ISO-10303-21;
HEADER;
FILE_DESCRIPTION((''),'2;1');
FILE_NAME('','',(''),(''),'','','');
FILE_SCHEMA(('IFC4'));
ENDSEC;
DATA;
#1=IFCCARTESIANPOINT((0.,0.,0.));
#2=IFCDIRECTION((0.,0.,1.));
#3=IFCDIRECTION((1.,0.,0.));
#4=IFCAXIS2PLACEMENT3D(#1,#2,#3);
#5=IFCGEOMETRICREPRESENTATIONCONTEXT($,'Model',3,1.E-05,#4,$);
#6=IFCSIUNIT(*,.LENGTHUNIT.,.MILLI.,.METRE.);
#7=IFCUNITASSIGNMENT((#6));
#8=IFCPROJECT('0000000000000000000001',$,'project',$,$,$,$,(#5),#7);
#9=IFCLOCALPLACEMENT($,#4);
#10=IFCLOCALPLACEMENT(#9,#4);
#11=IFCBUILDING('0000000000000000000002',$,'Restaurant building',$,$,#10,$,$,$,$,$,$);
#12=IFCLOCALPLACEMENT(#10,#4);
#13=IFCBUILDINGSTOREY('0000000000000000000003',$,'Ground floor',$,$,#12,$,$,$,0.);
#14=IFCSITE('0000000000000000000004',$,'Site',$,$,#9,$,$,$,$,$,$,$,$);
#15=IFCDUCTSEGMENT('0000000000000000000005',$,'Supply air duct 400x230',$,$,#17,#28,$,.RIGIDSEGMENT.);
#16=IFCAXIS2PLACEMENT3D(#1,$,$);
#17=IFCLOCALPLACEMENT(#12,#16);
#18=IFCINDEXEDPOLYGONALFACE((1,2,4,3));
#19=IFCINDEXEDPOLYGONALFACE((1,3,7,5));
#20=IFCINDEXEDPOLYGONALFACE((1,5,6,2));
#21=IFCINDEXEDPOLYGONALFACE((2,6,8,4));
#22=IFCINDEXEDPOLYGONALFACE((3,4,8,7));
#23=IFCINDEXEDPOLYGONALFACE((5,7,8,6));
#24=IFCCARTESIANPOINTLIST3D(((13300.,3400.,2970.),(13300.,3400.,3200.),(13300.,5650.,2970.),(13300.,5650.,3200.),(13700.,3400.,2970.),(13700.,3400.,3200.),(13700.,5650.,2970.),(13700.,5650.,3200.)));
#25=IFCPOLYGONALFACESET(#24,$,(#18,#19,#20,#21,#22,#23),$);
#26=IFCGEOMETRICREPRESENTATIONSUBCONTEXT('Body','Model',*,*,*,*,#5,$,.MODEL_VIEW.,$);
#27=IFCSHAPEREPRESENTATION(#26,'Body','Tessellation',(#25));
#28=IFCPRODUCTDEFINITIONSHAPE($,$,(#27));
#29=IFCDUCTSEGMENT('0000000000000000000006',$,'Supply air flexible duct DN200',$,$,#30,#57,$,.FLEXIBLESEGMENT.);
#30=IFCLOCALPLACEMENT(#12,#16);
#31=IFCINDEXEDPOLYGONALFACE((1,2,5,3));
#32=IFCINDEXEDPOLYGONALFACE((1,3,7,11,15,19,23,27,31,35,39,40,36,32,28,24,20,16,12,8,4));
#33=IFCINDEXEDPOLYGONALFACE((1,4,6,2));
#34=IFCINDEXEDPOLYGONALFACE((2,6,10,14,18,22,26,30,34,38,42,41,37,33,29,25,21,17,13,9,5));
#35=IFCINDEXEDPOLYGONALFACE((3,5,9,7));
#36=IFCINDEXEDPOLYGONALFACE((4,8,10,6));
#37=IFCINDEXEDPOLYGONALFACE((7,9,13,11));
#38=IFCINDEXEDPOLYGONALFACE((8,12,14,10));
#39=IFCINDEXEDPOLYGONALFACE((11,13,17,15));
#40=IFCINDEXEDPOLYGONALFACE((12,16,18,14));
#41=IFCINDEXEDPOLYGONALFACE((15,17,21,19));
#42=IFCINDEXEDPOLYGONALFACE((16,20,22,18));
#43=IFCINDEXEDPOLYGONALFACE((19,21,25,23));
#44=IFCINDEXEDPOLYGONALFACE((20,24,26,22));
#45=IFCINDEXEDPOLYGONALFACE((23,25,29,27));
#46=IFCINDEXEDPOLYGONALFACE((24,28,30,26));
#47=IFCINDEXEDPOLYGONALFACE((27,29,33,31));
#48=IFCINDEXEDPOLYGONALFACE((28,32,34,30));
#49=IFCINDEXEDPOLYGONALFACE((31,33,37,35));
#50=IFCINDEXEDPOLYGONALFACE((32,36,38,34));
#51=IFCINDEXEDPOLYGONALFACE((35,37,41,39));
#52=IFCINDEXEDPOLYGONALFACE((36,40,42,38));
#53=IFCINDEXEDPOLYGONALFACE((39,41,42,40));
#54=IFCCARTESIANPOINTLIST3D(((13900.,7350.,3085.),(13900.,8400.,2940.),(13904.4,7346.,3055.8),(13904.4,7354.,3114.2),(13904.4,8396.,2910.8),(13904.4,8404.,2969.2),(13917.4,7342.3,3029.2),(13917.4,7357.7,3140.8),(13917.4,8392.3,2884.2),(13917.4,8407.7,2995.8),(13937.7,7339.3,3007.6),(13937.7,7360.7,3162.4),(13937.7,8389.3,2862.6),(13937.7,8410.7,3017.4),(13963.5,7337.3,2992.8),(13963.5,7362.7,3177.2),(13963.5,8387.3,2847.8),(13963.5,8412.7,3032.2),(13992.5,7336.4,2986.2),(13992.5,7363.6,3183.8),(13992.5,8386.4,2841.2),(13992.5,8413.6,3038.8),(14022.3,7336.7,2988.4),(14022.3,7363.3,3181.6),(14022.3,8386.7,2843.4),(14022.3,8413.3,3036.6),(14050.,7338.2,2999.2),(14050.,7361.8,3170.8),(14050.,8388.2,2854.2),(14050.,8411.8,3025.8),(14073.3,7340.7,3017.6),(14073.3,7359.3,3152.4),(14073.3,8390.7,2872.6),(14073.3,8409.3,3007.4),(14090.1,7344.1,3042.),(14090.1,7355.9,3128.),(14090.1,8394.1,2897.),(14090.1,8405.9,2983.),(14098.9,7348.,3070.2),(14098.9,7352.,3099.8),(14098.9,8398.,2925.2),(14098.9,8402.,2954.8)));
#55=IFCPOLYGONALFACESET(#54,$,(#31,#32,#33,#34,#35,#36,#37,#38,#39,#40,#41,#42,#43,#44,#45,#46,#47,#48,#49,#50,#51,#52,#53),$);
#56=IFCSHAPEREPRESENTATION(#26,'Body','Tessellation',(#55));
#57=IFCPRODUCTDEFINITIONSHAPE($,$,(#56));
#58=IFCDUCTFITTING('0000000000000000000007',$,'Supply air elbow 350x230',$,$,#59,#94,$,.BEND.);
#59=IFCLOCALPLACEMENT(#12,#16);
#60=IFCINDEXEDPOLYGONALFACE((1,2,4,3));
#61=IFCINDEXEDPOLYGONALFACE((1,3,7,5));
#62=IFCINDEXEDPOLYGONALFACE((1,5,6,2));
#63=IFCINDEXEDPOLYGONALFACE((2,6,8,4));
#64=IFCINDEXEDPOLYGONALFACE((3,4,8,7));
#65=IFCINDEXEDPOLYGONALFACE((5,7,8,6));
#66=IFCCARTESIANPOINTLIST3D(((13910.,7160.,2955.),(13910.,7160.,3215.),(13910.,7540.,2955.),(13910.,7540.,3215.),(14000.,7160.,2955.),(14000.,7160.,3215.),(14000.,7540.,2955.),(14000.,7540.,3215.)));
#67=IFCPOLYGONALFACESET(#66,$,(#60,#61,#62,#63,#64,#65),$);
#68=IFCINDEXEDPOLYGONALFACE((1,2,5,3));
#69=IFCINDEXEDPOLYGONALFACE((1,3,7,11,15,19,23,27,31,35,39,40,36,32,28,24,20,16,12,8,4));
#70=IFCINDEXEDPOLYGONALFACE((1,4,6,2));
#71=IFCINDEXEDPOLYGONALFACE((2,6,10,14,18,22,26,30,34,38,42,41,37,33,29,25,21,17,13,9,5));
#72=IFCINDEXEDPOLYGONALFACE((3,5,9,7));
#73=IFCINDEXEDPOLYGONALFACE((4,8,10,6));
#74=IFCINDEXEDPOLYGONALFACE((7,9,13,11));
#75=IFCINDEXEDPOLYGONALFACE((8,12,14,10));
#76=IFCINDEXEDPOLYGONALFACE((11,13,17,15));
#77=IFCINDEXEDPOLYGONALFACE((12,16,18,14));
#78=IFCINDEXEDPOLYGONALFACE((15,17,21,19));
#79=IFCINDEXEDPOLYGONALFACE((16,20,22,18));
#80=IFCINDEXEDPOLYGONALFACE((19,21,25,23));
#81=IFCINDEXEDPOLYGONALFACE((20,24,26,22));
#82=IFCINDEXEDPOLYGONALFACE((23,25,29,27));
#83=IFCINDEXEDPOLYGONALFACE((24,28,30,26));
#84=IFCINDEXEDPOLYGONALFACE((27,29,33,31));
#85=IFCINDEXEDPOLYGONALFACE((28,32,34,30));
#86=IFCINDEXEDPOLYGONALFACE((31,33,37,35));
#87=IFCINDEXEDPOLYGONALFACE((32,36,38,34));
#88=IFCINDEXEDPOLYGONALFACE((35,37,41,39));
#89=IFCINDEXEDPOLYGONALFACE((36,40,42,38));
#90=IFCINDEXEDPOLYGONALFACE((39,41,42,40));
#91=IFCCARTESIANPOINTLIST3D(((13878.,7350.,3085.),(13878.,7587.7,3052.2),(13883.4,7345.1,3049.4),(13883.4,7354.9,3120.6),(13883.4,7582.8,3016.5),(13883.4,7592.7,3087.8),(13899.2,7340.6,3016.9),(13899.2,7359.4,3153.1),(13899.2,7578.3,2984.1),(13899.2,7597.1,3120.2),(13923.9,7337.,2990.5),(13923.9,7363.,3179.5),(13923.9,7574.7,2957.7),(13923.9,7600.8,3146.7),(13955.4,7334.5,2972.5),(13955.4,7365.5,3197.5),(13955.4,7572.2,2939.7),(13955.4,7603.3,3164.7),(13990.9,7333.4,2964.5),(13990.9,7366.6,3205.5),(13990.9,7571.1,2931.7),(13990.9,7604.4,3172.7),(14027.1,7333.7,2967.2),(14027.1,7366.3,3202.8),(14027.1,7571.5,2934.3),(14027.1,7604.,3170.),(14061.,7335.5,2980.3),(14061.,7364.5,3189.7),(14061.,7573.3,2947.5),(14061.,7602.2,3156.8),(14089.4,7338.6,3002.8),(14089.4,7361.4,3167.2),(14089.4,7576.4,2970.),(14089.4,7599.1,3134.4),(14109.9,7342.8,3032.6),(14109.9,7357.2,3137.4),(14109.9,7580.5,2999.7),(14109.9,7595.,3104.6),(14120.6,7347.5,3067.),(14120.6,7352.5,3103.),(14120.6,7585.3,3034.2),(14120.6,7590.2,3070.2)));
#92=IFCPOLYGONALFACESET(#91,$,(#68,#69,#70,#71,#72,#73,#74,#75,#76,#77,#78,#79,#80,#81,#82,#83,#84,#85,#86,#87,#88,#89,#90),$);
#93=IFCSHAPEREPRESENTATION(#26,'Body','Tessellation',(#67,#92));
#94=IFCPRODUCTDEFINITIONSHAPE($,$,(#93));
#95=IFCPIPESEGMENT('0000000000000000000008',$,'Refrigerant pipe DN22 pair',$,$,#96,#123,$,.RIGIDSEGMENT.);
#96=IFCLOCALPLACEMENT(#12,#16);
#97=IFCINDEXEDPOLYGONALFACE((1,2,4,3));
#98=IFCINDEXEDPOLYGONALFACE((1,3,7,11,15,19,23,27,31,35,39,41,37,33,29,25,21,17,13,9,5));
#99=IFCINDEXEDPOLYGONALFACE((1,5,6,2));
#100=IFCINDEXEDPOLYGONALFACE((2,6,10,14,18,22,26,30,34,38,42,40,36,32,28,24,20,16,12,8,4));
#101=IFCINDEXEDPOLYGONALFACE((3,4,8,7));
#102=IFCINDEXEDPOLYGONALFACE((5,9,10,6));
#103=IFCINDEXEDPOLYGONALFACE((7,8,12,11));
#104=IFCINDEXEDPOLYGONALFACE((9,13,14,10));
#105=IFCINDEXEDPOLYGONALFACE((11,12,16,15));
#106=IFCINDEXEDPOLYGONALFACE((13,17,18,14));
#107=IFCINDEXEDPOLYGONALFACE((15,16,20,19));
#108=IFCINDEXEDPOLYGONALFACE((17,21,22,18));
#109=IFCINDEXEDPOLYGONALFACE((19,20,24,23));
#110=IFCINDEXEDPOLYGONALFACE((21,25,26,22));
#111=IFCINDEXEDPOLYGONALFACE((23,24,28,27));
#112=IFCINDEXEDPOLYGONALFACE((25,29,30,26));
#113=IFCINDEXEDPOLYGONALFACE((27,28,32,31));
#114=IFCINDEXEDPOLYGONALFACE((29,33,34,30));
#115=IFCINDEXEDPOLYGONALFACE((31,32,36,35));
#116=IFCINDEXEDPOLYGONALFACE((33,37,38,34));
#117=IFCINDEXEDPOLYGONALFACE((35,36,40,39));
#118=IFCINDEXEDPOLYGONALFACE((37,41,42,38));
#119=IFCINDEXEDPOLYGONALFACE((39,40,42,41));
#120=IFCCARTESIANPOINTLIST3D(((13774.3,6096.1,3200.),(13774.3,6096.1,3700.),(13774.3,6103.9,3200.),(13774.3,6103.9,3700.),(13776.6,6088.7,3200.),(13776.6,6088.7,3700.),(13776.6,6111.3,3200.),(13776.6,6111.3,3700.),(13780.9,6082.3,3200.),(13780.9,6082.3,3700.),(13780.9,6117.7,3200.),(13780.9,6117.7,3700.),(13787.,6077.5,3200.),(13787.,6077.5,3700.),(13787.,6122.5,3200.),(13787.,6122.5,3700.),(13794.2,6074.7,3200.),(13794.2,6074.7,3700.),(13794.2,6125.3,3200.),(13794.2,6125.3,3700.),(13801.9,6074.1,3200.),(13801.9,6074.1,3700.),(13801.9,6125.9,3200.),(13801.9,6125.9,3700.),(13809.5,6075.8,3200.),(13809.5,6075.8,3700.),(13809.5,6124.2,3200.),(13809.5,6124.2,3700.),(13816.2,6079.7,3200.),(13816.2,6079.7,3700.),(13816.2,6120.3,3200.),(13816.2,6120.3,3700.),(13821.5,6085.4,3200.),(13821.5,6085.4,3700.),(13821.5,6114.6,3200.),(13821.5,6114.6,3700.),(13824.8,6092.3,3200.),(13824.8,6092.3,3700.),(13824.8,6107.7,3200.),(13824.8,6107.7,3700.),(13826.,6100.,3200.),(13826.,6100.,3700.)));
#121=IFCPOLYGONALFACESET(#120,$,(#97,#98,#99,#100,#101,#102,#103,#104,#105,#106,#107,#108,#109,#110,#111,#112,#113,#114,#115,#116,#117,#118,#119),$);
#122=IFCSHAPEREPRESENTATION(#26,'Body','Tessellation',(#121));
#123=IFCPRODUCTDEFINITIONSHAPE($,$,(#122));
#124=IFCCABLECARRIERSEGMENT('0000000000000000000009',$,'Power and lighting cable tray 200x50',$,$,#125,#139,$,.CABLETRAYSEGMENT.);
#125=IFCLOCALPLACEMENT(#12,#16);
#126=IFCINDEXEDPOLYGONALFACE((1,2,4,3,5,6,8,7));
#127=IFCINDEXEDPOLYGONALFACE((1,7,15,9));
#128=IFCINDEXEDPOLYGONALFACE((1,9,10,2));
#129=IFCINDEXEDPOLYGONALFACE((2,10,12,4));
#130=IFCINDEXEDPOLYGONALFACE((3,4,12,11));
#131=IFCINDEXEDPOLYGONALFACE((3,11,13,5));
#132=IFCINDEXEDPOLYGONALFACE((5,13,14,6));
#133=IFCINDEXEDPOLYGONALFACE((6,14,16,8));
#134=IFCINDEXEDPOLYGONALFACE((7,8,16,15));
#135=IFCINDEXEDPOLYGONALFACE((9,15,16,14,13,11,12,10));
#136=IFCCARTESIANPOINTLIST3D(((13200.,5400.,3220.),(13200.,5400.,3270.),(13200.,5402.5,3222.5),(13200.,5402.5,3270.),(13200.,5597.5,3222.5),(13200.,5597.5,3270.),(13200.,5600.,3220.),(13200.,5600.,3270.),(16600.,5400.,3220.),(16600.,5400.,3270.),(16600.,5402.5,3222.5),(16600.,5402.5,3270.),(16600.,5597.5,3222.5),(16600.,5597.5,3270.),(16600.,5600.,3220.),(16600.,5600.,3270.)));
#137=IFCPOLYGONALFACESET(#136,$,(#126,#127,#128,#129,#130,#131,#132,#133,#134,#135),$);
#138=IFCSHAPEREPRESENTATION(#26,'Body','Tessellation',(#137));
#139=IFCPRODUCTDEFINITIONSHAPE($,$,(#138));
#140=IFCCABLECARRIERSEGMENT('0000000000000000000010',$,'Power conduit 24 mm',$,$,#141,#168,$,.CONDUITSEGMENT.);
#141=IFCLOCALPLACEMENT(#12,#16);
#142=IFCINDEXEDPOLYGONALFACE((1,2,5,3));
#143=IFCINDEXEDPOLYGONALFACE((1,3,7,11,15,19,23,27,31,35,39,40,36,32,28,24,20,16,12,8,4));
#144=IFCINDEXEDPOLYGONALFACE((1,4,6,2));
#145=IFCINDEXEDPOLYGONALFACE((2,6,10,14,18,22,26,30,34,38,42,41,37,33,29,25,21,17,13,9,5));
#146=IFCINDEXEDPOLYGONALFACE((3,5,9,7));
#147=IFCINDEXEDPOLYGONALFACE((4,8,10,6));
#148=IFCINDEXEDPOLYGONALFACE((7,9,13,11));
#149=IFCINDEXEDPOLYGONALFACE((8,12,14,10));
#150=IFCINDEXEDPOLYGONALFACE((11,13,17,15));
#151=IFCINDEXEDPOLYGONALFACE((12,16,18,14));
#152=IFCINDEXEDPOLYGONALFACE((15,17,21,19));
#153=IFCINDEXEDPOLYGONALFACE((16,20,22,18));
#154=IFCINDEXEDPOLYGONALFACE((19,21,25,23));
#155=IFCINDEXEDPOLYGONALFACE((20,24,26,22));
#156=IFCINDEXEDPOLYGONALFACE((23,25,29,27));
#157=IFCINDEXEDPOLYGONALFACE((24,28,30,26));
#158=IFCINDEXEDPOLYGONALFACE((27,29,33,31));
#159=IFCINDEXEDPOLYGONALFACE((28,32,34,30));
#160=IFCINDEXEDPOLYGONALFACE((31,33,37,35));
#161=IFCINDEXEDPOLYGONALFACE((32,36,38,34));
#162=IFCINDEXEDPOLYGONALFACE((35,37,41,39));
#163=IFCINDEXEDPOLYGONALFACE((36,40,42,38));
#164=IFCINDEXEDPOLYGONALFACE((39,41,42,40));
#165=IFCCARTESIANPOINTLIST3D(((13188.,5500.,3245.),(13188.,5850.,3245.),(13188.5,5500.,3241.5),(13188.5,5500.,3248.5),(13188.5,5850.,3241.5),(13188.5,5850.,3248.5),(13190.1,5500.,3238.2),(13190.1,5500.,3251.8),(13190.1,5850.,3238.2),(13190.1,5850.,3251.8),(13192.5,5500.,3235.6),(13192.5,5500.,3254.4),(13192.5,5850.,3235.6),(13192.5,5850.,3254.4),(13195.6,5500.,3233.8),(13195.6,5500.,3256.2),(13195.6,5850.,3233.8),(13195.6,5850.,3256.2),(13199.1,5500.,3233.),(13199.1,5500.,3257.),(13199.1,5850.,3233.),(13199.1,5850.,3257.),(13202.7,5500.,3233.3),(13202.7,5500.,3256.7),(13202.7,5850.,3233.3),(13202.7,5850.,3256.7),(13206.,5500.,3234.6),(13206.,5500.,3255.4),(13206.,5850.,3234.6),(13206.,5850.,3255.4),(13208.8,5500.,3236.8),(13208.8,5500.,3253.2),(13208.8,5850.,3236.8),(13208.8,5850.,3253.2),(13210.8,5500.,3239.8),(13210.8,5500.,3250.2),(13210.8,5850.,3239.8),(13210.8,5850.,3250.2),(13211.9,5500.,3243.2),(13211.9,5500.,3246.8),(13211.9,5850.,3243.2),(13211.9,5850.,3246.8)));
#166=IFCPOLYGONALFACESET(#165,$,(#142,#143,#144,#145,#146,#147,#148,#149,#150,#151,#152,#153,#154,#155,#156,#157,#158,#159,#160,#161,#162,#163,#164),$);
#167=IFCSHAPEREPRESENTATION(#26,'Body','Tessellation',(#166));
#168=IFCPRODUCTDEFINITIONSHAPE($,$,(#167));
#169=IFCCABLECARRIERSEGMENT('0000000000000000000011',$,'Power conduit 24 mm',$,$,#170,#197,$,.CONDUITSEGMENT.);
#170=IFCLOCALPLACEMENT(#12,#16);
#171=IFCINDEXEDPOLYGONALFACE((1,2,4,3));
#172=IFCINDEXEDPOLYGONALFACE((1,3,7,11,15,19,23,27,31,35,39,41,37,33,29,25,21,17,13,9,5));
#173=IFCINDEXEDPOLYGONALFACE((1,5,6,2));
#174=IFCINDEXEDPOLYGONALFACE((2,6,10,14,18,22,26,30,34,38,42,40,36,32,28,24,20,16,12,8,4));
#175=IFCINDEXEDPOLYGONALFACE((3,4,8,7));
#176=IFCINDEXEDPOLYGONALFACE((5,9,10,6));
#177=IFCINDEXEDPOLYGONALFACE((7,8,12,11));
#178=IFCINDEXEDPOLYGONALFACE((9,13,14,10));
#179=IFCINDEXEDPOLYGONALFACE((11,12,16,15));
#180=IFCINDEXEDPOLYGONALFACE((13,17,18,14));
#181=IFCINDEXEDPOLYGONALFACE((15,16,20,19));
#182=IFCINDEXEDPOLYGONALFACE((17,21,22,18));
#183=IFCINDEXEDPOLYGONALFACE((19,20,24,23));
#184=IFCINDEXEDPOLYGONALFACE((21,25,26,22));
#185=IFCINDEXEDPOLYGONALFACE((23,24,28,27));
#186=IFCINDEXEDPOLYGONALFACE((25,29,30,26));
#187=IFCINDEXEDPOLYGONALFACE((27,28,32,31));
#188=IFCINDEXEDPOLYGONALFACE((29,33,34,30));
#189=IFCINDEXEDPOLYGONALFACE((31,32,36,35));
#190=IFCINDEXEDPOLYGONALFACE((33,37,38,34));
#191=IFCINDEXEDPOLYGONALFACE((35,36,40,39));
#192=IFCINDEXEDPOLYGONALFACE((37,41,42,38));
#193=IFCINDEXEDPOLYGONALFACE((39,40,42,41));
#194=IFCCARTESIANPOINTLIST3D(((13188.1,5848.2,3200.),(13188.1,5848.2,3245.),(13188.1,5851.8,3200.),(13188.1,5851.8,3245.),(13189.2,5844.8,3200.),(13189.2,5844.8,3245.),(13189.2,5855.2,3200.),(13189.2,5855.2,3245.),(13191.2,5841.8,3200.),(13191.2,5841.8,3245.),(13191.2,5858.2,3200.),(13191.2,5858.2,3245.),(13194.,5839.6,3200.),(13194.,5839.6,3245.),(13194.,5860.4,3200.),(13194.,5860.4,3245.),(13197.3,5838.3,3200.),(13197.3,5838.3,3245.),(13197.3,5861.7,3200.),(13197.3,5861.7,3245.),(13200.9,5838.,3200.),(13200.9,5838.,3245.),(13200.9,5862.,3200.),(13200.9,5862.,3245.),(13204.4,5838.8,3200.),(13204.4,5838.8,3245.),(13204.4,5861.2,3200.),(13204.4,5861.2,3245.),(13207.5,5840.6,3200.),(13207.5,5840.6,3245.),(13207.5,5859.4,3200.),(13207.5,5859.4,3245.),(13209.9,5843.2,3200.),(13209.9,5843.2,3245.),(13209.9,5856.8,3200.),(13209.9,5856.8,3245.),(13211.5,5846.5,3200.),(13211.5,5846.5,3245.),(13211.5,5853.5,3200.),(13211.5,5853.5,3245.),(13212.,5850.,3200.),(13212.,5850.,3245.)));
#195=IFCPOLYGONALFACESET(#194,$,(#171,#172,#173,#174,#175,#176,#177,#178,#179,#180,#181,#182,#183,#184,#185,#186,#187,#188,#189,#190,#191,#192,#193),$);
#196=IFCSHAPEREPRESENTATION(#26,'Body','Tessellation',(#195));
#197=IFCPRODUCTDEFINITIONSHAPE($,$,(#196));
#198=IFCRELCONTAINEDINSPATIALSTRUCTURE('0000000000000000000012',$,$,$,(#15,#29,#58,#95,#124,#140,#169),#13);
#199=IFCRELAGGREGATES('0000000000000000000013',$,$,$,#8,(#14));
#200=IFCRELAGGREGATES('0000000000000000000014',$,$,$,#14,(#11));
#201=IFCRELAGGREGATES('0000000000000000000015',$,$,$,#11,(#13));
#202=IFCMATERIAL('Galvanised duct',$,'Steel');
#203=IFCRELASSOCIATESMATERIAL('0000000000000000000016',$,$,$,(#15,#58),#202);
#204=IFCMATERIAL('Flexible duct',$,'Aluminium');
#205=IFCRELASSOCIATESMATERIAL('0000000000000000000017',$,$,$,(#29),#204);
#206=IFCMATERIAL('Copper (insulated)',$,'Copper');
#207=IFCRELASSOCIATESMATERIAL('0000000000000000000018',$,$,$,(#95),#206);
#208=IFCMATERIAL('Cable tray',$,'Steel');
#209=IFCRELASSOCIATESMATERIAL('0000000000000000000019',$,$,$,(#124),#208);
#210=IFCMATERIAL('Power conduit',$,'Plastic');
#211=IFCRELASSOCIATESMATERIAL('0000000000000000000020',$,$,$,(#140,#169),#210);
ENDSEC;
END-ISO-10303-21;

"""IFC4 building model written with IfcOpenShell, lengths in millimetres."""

from ifc_helpers import new_model, si_unit, frame, origin_with_axes, origin_2d, place, context, subcontext, project, spatial, polyline, rectangle, circle, outline, extrude, material, element, save


model = new_model("IFC4")

# Units and contexts
model_context = context("Model", 3, precision=1e-05, world=origin_with_axes())
body_context = subcontext(model_context, "Body", "Model", "MODEL_VIEW")
ifc_project = project(units=[si_unit("LENGTHUNIT", "METRE", prefix="MILLI")], contexts=[model_context])

# Site, building, storey
site_placement = place(None, origin_with_axes())
site = spatial("IfcSite", under=ifc_project, at=site_placement, Name="Site")
building_placement = place(site_placement, origin_with_axes())
building = spatial("IfcBuilding", under=site, at=building_placement, Name="Restaurant building")
storey_placement = place(building_placement, origin_with_axes())
storey = spatial("IfcBuildingStorey", under=building, at=storey_placement, Name="Ground floor", Elevation=0.0)

# Duct segments
ifc_material_1 = material(Name="Galvanised duct", Category="Steel")
duct_segment_1_placement = place(storey_placement, frame((13500.0, 5650.0, 3085.0)))
element("IfcDuctSegment", 1, at=duct_segment_1_placement, inside=storey, material=ifc_material_1, Name="Supply air duct 400x230", PredefinedType="RIGIDSEGMENT", context=body_context, shape_type="SweptSolid", body=[
    extrude(rectangle(XDim=400.0, YDim=230.0, at=origin_2d()), frame((0.0, 0.0, 0.0), z_axis=(0.0, -1.0, 0.0), x_axis=(1.0, 0.0, 0.0)), (0.0, 0.0, 1.0), 2250.0),
])
ifc_material_2 = material(Name="Flexible duct", Category="Aluminium")
duct_segment_2_placement = place(storey_placement, frame((14000.0, 7350.0, 3085.0)))
element("IfcDuctSegment", 2, at=duct_segment_2_placement, inside=storey, material=ifc_material_2, Name="Supply air flexible duct DN200", PredefinedType="FLEXIBLESEGMENT", context=body_context, shape_type="SweptSolid", body=[
    extrude(circle(Radius=100.0, at=origin_2d()), frame((0.0, 0.0, 0.0), z_axis=(0.0, 0.990599, -0.136797), x_axis=(-1.0, 0.0, 0.0)), (0.0, 0.0, 1.0), 1060.0),
])

# Duct fitting
duct_fitting_placement = place(storey_placement, frame((14000.0, 7350.0, 3085.0)))
element("IfcDuctFitting", 3, at=duct_fitting_placement, inside=storey, material=ifc_material_1, Name="Supply air elbow 350x230", PredefinedType="BEND", context=body_context, shape_type="SweptSolid", body=[
    extrude(rectangle(XDim=380.0, YDim=260.0, at=origin_2d()), frame((0.0, 0.0, 0.0), z_axis=(-1.0, 0.0, 0.0), x_axis=(0.0, -1.0, 0.0)), (0.0, 0.0, 1.0), 90.0),
    extrude(circle(Radius=122.0, at=origin_2d()), frame((0.0, 0.0, 0.0), z_axis=(0.0, 0.990599, -0.136797), x_axis=(-1.0, 0.0, 0.0)), (0.0, 0.0, 1.0), 240.0),
])

# Pipe segment
ifc_material_3 = material(Name="Copper (insulated)", Category="Copper")
pipe_segment_1_placement = place(storey_placement, frame((13800.0, 6100.0, 3700.0)))
element("IfcPipeSegment", 4, at=pipe_segment_1_placement, inside=storey, material=ifc_material_3, Name="Refrigerant pipe DN22 pair", PredefinedType="RIGIDSEGMENT", context=body_context, shape_type="SweptSolid", body=[
    extrude(circle(Radius=26.0, at=origin_2d()), frame((0.0, 0.0, 0.0), z_axis=(0.0, 0.0, -1.0), x_axis=(1.0, 0.0, 0.0)), (0.0, 0.0, 1.0), 500.0),
])

# Cable carrier segments
ifc_material_4 = material(Name="Cable tray", Category="Steel")
cable_carrier_segment_1_placement = place(storey_placement, frame((13200.0, 5500.0, 3245.0)))
element("IfcCableCarrierSegment", 5, at=cable_carrier_segment_1_placement, inside=storey, material=ifc_material_4, Name="Power and lighting cable tray 200x50", PredefinedType="CABLETRAYSEGMENT", context=body_context, shape_type="SweptSolid", body=[
    extrude(outline(polyline([(-100.0, -25.0), (100.0, -25.0), (100.0, 25.0), (97.5, 25.0), (97.5, -22.5), (-97.5, -22.5), (-97.5, 25.0), (-100.0, 25.0), (-100.0, -25.0)])), frame((0.0, 0.0, 0.0), z_axis=(1.0, 0.0, 0.0), x_axis=(0.0, 1.0, 0.0)), (0.0, 0.0, 1.0), 3400.0),
])
ifc_material_5 = material(Name="Power conduit", Category="Plastic")
cable_carrier_segment_2_placement = place(storey_placement, frame((13200.0, 5500.0, 3245.0)))
element("IfcCableCarrierSegment", 6, at=cable_carrier_segment_2_placement, inside=storey, material=ifc_material_5, Name="Power conduit 24 mm", PredefinedType="CONDUITSEGMENT", context=body_context, shape_type="SweptSolid", body=[
    extrude(circle(Radius=12.0, at=origin_2d()), frame((0.0, 0.0, 0.0), z_axis=(0.0, 1.0, 0.0), x_axis=(-1.0, 0.0, 0.0)), (0.0, 0.0, 1.0), 350.0),
])
cable_carrier_segment_3_placement = place(storey_placement, frame((13200.0, 5850.0, 3245.0)))
element("IfcCableCarrierSegment", 7, at=cable_carrier_segment_3_placement, inside=storey, material=ifc_material_5, Name="Power conduit 24 mm", PredefinedType="CONDUITSEGMENT", context=body_context, shape_type="SweptSolid", body=[
    extrude(circle(Radius=12.0, at=origin_2d()), frame((0.0, 0.0, 0.0), z_axis=(0.0, 0.0, -1.0), x_axis=(1.0, 0.0, 0.0)), (0.0, 0.0, 1.0), 45.0),
])

save(model, "model.ifc")
